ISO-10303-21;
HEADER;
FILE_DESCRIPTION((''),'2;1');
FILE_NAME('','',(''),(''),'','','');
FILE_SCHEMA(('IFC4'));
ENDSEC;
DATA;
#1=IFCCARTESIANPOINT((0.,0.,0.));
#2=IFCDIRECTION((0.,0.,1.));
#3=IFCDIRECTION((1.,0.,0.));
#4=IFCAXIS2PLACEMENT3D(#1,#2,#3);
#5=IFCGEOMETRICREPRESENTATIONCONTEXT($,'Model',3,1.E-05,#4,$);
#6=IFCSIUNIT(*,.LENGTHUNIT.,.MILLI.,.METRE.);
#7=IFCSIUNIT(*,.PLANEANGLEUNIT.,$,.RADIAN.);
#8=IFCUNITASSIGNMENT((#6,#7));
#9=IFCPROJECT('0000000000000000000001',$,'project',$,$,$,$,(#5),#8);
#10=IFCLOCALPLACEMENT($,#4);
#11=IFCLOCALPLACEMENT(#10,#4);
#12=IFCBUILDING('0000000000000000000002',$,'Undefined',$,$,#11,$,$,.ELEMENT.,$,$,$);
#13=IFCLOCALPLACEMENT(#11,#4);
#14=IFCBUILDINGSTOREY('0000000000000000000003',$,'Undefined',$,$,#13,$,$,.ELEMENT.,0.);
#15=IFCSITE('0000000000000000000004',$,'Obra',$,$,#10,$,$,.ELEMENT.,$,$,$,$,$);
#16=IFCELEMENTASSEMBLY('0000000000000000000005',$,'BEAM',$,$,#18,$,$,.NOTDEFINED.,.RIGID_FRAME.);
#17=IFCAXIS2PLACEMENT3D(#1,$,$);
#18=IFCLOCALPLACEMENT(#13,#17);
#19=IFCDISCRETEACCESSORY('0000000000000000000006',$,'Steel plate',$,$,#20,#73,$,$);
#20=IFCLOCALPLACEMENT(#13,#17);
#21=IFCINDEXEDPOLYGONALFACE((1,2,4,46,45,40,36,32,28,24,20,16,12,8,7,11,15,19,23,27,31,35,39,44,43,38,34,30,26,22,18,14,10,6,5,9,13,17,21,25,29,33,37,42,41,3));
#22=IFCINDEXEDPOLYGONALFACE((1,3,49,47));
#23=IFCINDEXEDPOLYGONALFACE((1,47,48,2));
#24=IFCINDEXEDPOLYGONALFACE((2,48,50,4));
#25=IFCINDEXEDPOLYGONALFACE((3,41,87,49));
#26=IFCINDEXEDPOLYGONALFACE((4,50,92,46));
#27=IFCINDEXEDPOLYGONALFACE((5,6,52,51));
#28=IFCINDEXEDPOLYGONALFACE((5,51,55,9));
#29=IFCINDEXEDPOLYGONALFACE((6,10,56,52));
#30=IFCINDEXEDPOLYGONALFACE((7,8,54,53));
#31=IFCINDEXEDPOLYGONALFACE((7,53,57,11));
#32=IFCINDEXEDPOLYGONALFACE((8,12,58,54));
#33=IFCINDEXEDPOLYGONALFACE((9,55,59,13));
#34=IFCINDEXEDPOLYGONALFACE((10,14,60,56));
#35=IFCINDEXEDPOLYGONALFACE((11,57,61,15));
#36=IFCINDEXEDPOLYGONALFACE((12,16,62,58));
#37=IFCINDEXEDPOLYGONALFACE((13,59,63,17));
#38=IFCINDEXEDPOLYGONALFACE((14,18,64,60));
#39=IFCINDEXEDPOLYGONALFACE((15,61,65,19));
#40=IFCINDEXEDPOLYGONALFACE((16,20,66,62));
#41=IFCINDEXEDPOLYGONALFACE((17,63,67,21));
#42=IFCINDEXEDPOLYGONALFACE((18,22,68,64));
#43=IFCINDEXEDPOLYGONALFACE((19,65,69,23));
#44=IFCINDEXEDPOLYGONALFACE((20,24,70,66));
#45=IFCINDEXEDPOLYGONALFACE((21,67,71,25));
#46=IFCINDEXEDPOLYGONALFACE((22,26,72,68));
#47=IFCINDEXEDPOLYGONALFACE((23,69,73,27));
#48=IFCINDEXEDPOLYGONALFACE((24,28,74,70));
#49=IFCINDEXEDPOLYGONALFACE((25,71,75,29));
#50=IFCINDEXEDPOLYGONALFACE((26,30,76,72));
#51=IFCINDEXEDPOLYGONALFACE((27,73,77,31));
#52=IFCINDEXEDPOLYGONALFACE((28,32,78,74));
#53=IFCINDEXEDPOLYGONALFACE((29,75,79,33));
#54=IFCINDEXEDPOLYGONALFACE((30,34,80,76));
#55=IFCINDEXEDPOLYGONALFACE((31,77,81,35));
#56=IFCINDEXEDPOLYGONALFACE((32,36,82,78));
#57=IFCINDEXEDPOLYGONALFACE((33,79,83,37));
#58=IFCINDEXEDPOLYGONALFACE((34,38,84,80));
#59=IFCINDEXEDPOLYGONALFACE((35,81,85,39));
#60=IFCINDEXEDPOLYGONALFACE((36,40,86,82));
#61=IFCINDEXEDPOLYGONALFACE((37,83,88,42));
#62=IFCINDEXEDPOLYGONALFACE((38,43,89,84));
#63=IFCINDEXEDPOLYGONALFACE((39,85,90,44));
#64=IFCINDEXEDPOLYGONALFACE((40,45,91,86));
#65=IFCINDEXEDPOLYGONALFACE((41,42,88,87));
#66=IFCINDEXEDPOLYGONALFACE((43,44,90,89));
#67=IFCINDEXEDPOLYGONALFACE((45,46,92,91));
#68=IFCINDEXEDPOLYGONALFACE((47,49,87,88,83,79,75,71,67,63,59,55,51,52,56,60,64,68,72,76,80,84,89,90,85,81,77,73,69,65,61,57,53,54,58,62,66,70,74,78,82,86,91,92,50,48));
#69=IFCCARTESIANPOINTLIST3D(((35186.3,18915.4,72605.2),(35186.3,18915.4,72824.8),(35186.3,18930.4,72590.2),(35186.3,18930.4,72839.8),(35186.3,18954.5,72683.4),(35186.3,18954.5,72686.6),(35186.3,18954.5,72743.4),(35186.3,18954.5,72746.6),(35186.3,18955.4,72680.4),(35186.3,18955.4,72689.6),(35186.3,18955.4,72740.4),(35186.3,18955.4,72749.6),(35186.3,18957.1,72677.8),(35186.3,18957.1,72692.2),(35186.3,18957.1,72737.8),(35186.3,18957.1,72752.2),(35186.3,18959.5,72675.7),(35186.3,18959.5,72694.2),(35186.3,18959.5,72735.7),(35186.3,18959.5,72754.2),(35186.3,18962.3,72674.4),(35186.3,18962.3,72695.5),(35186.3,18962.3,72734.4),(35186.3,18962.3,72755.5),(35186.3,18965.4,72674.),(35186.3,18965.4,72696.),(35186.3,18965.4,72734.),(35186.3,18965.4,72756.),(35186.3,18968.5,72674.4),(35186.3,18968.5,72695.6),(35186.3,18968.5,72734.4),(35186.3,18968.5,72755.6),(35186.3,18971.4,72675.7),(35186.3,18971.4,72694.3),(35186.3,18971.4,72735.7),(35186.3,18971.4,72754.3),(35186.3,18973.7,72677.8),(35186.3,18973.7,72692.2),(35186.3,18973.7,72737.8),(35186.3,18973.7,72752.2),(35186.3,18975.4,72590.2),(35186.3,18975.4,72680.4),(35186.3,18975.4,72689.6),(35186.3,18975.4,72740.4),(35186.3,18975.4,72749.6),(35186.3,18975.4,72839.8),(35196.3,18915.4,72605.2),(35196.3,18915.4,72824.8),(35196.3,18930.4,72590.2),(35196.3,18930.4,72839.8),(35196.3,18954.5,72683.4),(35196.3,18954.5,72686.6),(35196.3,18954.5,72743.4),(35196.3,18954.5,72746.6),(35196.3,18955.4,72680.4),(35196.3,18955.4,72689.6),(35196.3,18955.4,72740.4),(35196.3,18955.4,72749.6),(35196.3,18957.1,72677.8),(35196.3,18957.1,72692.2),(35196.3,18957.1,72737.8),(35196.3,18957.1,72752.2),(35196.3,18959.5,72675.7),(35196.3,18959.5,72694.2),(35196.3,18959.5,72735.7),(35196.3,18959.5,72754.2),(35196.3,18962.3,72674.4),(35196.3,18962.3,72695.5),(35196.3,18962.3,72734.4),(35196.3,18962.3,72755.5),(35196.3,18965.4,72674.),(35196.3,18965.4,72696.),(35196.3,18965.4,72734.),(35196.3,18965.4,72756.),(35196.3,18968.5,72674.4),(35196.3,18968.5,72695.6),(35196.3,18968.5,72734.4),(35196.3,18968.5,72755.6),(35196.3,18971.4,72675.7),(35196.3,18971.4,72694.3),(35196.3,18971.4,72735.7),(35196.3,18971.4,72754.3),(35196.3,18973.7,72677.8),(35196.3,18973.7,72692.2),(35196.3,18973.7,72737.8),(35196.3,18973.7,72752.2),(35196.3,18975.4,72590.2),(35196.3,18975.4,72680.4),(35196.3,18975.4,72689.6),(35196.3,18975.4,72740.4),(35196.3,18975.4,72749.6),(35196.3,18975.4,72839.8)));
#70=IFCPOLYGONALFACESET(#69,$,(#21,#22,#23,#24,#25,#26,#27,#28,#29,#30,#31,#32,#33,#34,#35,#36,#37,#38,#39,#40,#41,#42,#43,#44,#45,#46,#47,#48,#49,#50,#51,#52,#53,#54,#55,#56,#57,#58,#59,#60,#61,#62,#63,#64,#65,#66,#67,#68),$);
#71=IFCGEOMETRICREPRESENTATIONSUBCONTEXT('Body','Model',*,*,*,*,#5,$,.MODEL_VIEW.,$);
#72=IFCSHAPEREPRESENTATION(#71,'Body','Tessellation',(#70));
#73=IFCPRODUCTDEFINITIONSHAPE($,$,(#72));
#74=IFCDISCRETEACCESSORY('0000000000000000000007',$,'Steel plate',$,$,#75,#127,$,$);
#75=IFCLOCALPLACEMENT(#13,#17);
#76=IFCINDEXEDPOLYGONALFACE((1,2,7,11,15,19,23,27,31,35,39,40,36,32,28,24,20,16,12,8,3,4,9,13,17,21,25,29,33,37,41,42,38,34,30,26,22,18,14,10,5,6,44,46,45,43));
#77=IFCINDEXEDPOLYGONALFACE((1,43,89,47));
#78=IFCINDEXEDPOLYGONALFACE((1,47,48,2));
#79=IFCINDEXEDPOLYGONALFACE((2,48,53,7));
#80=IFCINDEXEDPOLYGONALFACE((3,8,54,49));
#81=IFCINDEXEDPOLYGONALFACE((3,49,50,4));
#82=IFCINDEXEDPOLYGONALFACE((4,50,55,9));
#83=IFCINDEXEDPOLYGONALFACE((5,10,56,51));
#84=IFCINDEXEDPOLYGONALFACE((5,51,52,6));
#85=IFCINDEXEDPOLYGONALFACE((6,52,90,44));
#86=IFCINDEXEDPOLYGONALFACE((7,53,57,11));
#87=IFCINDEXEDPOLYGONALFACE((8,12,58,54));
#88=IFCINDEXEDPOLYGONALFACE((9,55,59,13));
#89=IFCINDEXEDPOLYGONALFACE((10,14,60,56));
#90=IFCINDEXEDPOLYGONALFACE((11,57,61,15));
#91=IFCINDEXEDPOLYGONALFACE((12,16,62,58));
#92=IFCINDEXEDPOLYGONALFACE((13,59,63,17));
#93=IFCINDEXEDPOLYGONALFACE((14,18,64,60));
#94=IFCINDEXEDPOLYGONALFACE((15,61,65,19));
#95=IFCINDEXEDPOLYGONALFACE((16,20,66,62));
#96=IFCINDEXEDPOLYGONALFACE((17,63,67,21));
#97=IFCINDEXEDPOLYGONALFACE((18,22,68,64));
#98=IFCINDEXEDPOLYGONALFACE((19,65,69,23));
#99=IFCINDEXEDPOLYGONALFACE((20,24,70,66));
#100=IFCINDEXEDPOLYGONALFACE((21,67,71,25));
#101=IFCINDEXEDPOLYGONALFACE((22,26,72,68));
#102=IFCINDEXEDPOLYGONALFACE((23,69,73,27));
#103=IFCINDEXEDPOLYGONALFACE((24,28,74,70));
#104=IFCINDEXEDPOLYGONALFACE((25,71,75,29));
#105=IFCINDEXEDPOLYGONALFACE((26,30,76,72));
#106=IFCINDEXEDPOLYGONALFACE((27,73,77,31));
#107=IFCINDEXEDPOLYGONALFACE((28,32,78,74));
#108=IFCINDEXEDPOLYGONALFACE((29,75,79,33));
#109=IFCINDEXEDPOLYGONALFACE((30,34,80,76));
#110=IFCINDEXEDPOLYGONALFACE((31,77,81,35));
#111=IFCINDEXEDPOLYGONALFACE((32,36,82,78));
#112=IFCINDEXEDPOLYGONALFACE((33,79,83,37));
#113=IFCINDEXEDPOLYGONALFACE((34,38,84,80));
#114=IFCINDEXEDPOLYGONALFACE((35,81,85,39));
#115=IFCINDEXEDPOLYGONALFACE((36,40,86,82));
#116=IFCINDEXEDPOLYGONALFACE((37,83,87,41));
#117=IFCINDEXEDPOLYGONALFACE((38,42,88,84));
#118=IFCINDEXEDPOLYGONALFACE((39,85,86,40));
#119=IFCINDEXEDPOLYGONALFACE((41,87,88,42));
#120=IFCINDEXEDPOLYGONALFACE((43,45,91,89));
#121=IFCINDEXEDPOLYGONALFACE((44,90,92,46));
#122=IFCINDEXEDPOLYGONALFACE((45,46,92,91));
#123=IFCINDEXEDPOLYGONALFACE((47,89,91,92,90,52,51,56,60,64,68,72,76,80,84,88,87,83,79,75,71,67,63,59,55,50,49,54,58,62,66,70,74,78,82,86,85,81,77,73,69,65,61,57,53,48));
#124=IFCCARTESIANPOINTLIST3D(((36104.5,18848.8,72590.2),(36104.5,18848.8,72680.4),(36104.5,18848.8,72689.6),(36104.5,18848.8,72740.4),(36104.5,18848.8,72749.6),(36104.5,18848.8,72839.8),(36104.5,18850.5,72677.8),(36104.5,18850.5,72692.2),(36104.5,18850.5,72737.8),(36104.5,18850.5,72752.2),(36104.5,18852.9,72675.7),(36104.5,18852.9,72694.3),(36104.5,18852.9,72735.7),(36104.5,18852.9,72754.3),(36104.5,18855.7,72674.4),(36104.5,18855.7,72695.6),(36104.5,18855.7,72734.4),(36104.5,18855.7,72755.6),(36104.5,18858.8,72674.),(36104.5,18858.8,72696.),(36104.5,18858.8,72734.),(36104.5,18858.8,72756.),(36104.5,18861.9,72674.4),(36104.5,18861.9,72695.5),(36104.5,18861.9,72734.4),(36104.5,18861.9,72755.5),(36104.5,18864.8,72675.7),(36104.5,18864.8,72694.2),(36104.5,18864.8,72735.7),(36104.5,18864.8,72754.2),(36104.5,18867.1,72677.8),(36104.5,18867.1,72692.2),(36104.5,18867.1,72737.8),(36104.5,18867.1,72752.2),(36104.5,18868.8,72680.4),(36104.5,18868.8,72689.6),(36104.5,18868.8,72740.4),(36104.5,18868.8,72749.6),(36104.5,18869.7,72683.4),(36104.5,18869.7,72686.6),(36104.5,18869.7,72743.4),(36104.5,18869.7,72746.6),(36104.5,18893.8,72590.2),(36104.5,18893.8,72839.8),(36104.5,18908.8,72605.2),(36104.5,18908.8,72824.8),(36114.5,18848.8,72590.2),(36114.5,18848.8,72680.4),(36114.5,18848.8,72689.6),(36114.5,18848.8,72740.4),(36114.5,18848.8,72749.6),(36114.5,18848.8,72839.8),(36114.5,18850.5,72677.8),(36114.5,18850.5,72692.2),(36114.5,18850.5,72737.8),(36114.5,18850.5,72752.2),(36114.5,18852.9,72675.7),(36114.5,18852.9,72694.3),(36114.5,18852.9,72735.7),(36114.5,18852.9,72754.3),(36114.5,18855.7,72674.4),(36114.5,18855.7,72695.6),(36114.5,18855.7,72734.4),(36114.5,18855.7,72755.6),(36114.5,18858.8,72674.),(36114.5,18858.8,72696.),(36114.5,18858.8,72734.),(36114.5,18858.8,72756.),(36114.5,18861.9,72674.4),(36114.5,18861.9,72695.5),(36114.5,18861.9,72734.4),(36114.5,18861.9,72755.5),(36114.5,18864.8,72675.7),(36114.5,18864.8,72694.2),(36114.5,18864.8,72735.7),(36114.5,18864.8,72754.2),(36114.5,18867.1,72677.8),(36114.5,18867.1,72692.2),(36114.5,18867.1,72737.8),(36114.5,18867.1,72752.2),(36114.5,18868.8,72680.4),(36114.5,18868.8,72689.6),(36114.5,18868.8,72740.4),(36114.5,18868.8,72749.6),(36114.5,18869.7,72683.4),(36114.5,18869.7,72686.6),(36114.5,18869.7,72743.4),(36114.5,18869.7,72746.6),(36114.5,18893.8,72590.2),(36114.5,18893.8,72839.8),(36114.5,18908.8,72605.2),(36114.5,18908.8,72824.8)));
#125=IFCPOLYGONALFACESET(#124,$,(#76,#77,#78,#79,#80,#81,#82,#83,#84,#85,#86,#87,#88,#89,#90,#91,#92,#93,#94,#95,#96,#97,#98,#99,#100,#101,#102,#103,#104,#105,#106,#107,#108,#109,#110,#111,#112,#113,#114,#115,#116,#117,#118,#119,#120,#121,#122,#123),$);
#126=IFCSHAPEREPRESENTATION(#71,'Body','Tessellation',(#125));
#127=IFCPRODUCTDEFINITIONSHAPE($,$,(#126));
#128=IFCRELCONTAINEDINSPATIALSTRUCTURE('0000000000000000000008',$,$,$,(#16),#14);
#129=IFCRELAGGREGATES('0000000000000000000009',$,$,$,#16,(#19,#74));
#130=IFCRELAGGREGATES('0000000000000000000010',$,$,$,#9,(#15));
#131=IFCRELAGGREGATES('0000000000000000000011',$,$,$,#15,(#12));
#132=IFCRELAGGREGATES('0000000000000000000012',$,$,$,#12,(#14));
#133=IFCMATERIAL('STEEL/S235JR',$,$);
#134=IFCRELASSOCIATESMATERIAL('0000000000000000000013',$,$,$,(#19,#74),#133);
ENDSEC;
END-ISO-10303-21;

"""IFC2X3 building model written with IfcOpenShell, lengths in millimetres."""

from ifc_helpers import new_model, si_unit, frame, origin_with_axes, origin_2d_with_axis, place, context, subcontext, project, spatial, polyline, circle, outline, extrude, source, transform, mapped, material, element, aggregate, save


model = new_model("IFC2X3")

# Units and contexts
model_context = context("Model", 3, precision=1e-05, world=origin_with_axes())
body_context = subcontext(model_context, "Body", "Model", "MODEL_VIEW")
ifc_project = project(units=[si_unit("LENGTHUNIT", "METRE", prefix="MILLI"), si_unit("PLANEANGLEUNIT", "RADIAN")], contexts=[model_context])

# Site, building, storey
site_placement = place(None, origin_with_axes())
site = spatial("IfcSite", under=ifc_project, at=site_placement, Name="Obra", CompositionType="ELEMENT")
building_placement = place(site_placement, origin_with_axes())
building = spatial("IfcBuilding", under=site, at=building_placement, Name="Undefined", CompositionType="ELEMENT")
storey_placement = place(building_placement, origin_with_axes())
storey = spatial("IfcBuildingStorey", under=building, at=storey_placement, Name="Undefined", CompositionType="ELEMENT", Elevation=0.0)

# Shared definitions
ifc_material = material(Name="STEEL/S235JR")

# Shared definitions
shared_shape_1 = source(origin_with_axes(), body_context, "Body", "SweptSolid", [
    extrude(circle(Radius=11.0, at=origin_2d_with_axis()), frame((0.0, -13.4, 0.0), z_axis=(0.0, 1.0, 0.0), x_axis=(1.0, 0.0, 0.0)), (0.0, 0.0, 1.0), 10.2),
])

# Element assembly, discrete accessories, openings
assembly_1_placement = place(storey_placement, origin_with_axes())
assembly_1 = element("IfcElementAssembly", 1, at=assembly_1_placement, inside=storey, Name="BEAM", AssemblyPlace="NOTDEFINED", PredefinedType="RIGID_FRAME")
discrete_accessory_1_placement = place(assembly_1_placement, frame((35191.3, 18975.4, 72590.2), z_axis=(-1.0, 0.0, 0.0), x_axis=(0.0, -1.0, 0.0)))
discrete_accessory_1 = element("IfcDiscreteAccessory", 2, at=discrete_accessory_1_placement, material=ifc_material, Name="Steel plate", context=body_context, shape_type="SweptSolid", body=[
    extrude(outline(polyline([(0.0, 0.0), (45.0, 0.0), (60.0, 15.0), (60.0, 234.6), (45.0, 249.6), (0.0, 249.6), (0.0, 0.0)])), frame((0.0, 0.0, -5.0), z_axis=(0.0, 0.0, 1.0), x_axis=(1.0, 0.0, 0.0)), (0.0, 0.0, 1.0), 10.0),
])
opening_1_placement = place(assembly_1_placement, frame((35183.0, 18925.4, 72850.0), z_axis=(0.0, 1.0, 0.0), x_axis=(0.0, 0.0, -1.0)))
element("IfcOpeningElement", 3, at=opening_1_placement, cuts=discrete_accessory_1, ObjectType="Opening", context=body_context, shape_type="MappedRepresentation", body=[
    mapped(shared_shape_1, transform((105.0, 0.0, 40.0))),
    mapped(shared_shape_1, transform((165.0, 0.0, 40.0))),
])
discrete_accessory_2_placement = place(assembly_1_placement, frame((36109.5, 18848.8, 72590.2), z_axis=(1.0, 0.0, 0.0), x_axis=(0.0, 1.0, 0.0)))
discrete_accessory_2 = element("IfcDiscreteAccessory", 4, at=discrete_accessory_2_placement, material=ifc_material, Name="Steel plate", context=body_context, shape_type="SweptSolid", body=[
    extrude(outline(polyline([(0.0, 0.0), (45.0, 0.0), (60.0, 15.0), (60.0, 234.6), (45.0, 249.6), (0.0, 249.6), (0.0, 0.0)])), frame((0.0, 0.0, -5.0), z_axis=(0.0, 0.0, 1.0), x_axis=(1.0, 0.0, 0.0)), (0.0, 0.0, 1.0), 10.0),
])
opening_2_placement = place(assembly_1_placement, frame((36117.8, 18898.8, 72850.0), z_axis=(0.0, -1.0, 0.0), x_axis=(0.0, 0.0, -1.0)))
element("IfcOpeningElement", 5, at=opening_2_placement, cuts=discrete_accessory_2, ObjectType="Opening", context=body_context, shape_type="MappedRepresentation", body=[
    mapped(shared_shape_1, transform((105.0, 0.0, 40.0))),
    mapped(shared_shape_1, transform((165.0, 0.0, 40.0))),
])
aggregate(assembly_1, [discrete_accessory_1, discrete_accessory_2])

save(model, "model.ifc")
